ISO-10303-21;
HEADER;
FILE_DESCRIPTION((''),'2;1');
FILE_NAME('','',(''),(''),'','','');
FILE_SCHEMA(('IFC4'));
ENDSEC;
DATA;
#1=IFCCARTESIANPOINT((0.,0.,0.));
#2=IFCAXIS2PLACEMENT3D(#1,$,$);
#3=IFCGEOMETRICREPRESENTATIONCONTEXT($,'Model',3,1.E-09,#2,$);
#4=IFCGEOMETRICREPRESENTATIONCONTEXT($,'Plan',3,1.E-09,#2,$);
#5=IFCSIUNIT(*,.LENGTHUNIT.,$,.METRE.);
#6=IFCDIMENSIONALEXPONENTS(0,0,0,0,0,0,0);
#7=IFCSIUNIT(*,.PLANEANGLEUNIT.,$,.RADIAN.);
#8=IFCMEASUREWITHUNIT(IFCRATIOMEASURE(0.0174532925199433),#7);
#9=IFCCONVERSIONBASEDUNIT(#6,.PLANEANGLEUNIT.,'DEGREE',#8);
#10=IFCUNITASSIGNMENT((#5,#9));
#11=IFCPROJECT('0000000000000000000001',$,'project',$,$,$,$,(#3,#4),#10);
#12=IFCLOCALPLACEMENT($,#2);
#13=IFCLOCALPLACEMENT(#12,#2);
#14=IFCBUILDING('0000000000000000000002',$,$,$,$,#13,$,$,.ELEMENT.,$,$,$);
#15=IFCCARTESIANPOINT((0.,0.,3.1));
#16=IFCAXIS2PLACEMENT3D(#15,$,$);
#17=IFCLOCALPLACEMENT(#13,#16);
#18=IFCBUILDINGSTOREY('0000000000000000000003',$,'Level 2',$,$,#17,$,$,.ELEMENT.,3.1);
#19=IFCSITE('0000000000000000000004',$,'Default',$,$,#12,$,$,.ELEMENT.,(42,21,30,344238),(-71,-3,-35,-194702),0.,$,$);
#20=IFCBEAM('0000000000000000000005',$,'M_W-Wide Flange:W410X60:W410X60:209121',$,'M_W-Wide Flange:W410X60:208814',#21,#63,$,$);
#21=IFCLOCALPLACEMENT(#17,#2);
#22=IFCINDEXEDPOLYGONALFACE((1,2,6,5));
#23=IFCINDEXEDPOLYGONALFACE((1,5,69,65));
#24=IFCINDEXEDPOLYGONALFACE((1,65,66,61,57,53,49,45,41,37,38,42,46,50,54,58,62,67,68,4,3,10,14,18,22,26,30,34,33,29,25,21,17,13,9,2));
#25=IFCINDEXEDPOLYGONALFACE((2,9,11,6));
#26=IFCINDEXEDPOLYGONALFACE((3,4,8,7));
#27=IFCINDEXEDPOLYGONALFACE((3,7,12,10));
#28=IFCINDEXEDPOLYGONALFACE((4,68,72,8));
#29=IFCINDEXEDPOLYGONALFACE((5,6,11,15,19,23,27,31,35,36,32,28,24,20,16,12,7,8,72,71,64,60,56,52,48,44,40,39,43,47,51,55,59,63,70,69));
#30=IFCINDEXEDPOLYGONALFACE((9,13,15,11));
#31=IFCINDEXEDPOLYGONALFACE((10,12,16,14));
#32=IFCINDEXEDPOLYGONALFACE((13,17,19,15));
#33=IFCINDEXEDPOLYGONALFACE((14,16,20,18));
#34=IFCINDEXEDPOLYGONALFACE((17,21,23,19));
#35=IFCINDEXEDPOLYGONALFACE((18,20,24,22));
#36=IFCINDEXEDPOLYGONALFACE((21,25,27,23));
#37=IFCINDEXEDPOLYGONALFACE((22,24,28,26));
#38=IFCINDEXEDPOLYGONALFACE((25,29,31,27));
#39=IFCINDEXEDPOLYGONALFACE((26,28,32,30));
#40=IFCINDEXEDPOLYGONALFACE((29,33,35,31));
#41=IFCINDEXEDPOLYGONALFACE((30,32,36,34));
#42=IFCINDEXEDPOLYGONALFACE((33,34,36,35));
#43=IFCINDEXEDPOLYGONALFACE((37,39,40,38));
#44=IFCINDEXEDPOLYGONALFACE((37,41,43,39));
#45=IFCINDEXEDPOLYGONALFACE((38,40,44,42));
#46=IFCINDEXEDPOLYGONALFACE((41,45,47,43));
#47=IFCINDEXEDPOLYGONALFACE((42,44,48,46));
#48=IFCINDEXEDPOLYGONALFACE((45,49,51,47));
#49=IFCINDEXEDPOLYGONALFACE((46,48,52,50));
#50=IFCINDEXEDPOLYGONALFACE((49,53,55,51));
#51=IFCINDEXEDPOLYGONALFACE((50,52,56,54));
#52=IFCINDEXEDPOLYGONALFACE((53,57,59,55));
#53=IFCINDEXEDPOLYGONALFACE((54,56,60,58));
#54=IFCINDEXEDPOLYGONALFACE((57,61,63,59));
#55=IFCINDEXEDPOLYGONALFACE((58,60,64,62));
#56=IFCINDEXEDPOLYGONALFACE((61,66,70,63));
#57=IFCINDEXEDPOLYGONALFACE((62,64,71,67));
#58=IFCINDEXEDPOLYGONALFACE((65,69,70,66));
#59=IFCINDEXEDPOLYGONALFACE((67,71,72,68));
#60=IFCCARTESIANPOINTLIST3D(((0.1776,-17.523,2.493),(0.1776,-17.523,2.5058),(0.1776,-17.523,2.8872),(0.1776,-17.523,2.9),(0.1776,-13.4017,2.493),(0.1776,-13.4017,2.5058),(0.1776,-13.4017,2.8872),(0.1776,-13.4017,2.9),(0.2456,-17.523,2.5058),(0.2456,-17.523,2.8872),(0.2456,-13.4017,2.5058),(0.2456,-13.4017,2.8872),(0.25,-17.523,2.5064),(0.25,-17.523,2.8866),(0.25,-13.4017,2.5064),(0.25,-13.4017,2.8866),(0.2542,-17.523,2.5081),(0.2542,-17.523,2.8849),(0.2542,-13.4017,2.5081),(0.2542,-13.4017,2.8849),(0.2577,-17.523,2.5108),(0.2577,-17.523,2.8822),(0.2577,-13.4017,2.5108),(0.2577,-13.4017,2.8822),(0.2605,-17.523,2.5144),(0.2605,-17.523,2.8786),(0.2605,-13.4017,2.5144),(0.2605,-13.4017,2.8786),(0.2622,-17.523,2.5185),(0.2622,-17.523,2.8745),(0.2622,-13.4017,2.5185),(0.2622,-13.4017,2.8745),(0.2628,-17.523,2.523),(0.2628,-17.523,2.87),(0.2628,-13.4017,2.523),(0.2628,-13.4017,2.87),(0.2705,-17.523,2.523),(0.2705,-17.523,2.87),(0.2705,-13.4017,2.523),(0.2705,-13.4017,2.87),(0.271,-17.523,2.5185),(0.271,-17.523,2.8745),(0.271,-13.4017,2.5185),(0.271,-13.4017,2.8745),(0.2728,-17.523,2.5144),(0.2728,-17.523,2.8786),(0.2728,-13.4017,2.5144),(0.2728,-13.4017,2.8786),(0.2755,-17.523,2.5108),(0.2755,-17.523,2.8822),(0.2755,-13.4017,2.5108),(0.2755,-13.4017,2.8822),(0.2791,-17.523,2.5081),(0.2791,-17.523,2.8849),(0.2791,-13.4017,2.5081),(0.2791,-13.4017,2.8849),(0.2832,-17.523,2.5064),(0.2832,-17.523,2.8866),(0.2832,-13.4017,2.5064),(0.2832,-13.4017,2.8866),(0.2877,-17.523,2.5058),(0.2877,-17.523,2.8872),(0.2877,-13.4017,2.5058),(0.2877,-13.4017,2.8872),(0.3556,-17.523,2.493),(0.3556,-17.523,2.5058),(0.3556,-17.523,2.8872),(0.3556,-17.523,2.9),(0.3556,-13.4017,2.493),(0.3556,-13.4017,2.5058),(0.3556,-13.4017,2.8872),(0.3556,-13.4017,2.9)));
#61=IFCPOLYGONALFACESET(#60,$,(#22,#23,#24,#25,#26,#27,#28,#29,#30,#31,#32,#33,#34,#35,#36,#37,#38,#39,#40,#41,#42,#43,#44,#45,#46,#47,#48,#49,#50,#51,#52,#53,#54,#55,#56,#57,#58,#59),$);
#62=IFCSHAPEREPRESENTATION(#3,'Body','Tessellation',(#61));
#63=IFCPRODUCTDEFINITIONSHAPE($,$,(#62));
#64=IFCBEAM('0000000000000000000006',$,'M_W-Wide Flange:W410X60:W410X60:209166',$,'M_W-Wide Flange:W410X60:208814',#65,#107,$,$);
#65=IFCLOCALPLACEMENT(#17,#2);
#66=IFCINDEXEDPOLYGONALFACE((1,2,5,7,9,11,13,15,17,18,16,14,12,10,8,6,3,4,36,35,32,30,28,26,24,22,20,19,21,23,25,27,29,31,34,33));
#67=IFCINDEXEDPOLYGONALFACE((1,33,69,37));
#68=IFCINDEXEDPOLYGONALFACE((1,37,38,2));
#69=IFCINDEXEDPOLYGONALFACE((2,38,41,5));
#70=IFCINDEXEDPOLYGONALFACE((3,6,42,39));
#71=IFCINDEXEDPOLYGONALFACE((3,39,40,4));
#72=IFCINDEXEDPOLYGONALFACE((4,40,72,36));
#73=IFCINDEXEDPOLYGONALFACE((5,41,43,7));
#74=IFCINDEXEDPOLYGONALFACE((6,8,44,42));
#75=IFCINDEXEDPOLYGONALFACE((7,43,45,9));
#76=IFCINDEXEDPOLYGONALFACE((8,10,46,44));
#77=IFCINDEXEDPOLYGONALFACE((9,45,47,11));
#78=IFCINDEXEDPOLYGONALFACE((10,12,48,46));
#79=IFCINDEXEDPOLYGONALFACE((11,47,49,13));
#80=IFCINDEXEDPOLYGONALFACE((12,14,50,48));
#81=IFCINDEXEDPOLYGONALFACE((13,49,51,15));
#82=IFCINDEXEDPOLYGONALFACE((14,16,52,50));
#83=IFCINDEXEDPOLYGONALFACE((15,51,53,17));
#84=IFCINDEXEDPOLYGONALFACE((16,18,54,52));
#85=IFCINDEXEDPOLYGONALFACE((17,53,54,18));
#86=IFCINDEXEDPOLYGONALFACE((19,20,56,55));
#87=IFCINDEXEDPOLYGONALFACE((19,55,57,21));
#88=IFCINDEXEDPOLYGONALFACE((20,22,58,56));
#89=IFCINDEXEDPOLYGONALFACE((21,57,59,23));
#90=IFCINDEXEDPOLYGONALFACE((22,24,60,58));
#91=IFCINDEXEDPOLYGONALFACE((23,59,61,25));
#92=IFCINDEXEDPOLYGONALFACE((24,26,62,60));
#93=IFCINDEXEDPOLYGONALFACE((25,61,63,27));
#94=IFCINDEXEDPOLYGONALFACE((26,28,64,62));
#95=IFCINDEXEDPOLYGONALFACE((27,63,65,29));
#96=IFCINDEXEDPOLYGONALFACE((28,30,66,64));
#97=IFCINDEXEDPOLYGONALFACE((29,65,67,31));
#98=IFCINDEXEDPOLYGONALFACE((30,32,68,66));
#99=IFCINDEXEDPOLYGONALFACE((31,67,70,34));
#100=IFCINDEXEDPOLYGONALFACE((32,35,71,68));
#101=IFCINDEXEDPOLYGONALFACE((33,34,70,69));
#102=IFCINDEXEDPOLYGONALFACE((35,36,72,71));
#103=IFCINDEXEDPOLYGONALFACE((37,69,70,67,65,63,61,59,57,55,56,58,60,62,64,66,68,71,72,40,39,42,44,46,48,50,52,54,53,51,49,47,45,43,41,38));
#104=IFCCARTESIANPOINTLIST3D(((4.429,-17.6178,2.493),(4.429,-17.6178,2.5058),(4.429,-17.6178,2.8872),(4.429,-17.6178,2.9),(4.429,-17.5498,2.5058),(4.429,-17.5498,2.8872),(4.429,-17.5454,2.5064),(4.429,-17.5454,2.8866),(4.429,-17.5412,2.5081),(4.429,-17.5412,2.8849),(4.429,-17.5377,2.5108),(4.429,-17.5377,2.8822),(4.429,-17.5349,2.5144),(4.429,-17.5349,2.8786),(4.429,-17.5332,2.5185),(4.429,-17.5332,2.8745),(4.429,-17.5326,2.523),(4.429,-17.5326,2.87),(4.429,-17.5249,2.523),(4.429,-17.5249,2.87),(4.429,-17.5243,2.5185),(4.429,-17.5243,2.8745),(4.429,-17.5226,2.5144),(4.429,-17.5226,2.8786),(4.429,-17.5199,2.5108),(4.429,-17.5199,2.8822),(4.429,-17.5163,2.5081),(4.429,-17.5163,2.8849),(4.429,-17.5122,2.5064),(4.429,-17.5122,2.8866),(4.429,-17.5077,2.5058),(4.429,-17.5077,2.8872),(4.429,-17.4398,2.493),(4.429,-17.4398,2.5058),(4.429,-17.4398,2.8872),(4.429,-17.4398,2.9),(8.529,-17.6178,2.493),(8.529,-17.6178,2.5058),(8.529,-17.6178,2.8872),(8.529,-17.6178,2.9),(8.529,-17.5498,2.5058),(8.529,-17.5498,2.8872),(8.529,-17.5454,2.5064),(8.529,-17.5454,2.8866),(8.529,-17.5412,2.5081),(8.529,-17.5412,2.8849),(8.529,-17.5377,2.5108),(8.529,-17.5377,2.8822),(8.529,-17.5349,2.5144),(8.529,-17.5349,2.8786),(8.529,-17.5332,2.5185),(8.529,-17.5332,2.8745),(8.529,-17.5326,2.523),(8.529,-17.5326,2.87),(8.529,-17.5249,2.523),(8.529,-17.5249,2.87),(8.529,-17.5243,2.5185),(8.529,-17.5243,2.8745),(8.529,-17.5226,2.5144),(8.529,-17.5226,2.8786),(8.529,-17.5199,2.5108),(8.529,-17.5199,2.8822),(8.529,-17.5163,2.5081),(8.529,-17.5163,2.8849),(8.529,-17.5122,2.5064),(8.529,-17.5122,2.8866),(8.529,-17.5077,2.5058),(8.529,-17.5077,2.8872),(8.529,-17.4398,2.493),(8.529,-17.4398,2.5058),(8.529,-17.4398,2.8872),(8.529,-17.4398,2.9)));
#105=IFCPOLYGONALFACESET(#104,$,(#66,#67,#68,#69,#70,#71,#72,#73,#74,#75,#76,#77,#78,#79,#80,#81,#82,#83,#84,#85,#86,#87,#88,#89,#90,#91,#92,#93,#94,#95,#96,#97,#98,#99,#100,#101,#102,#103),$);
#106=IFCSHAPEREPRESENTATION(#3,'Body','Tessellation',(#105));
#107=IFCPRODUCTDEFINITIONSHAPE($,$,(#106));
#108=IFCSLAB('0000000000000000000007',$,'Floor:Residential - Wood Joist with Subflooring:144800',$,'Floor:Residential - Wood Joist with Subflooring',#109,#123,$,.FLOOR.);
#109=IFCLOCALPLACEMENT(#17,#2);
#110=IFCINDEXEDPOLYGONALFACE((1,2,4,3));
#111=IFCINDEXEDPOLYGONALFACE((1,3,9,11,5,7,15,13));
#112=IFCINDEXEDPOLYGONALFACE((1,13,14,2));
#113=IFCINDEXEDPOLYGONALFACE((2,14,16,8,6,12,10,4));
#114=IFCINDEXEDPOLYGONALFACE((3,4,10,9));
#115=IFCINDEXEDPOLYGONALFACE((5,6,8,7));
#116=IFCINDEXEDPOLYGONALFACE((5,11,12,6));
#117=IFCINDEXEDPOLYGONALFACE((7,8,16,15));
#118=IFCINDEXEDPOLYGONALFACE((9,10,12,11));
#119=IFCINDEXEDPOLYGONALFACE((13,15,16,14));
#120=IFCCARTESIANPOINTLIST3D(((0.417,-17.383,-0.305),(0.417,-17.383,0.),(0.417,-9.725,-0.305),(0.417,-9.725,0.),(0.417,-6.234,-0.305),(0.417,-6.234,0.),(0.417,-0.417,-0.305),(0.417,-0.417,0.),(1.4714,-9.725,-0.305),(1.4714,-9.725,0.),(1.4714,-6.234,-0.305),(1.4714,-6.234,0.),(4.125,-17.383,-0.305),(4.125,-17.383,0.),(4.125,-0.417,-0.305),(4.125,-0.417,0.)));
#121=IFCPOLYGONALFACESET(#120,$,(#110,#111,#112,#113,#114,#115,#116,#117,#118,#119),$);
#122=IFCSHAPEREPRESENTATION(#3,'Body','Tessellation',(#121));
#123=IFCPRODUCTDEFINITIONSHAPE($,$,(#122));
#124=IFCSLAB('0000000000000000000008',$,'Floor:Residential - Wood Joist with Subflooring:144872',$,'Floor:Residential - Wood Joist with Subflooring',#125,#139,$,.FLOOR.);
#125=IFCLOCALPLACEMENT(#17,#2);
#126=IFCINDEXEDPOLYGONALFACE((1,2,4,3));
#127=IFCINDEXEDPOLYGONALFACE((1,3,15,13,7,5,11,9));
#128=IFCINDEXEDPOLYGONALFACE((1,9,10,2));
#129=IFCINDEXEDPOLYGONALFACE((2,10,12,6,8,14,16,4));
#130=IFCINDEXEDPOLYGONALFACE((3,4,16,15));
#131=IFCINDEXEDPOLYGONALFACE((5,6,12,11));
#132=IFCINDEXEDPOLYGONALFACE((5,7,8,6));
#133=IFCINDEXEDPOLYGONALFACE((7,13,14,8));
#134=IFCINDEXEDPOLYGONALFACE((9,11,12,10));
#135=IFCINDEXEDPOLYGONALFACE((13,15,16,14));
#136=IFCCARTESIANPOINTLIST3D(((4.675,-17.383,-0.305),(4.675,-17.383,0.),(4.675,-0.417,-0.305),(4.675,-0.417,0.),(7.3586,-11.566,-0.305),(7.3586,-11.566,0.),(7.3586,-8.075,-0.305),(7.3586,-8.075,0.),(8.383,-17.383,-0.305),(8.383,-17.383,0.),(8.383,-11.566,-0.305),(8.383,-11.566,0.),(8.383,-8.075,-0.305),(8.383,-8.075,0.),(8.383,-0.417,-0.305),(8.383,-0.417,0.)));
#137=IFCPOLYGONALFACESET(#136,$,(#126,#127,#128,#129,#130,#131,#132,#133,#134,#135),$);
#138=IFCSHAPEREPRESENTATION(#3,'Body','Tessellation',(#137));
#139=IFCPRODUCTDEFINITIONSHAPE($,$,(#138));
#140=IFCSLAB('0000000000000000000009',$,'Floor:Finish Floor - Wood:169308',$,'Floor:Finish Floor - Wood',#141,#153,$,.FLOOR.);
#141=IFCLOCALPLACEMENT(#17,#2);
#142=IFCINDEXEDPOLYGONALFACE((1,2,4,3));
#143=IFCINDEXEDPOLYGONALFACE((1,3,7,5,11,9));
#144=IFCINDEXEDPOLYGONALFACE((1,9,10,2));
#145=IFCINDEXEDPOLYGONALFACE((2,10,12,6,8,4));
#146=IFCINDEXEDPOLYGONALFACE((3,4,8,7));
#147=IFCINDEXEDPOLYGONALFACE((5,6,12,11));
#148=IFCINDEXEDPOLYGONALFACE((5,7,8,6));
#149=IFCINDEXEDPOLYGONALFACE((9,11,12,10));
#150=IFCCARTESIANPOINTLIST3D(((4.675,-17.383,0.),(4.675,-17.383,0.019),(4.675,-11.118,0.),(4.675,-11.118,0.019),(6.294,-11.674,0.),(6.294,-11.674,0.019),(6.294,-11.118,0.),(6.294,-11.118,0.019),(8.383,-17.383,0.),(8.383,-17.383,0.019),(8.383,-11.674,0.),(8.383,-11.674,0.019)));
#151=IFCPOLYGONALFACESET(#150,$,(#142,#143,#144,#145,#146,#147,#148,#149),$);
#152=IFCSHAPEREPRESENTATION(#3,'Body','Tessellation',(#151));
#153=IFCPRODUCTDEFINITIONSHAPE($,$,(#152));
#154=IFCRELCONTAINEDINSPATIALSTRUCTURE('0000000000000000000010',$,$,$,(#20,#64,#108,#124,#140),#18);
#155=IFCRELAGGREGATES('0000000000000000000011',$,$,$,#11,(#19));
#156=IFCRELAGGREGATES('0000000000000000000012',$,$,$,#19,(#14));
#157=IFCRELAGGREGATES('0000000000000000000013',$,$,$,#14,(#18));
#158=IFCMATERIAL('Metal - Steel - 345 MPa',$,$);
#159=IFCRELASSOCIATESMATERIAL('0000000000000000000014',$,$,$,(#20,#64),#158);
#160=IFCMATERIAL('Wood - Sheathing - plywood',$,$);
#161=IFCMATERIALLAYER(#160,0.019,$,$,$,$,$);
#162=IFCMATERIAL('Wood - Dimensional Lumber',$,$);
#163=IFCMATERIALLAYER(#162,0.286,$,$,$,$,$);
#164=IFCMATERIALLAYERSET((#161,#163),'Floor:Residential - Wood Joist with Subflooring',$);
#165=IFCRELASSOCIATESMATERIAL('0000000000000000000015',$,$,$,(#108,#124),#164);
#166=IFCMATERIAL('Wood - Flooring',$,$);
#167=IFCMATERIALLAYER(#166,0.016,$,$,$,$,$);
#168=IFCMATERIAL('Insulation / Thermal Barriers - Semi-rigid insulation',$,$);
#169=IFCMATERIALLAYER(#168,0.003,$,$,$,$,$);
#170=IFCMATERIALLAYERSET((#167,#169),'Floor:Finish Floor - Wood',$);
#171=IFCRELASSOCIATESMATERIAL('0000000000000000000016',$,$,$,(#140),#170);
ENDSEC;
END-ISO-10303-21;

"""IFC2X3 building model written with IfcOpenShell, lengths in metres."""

from ifc_helpers import new_model, entity, si_unit, converted_unit, frame, frame_2d, origin, place, context, project, spatial, polyline, circle_curve, parameter, trimmed, segment, composite_curve, outline, extrude, material, layer, layer_set, layer_usage, element, save


model = new_model("IFC2X3")

# Units and contexts
model_context = context("Model", 3, precision=1e-09, world=origin())
plan_context = context("Plan", 3, precision=1e-09, world=origin())
ifc_project = project(units=[si_unit("LENGTHUNIT", "METRE"), converted_unit("PLANEANGLEUNIT", "DEGREE", entity("IfcRatioMeasure", 0.0174532925199433), si_unit("PLANEANGLEUNIT", "RADIAN"), dimensions=[0, 0, 0, 0, 0, 0, 0])], contexts=[model_context, plan_context])

# Site, building, storey
site_placement = place(None, origin())
site = spatial("IfcSite", under=ifc_project, at=site_placement, Name="Default", CompositionType="ELEMENT", RefLatitude=(42, 21, 30, 344238), RefLongitude=(-71, -3, -35, -194702), RefElevation=0.0)
building_placement = place(site_placement, origin())
building = spatial("IfcBuilding", under=site, at=building_placement, CompositionType="ELEMENT")
storey_placement = place(building_placement, frame((0.0, 0.0, 3.1)))
storey = spatial("IfcBuildingStorey", under=building, at=storey_placement, Name="Level 2", CompositionType="ELEMENT", Elevation=3.1)

# Beams
ifc_material_1 = material(Name="Metal - Steel - 345 MPa")
beam_1_placement = place(storey_placement, frame((0.2666, -13.4017, 2.9), z_axis=(0.0, 0.0, 1.0), x_axis=(-1.0, 0.0, 0.0)))
element("IfcBeam", 1, at=beam_1_placement, inside=storey, material=ifc_material_1, Name="M_W-Wide Flange:W410X60:W410X60:209121", ObjectType="M_W-Wide Flange:W410X60:208814", context=model_context, shape_type="SweptSolid", body=[
    extrude(outline(composite_curve([segment(polyline([(0.1907, -0.089), (0.2035, -0.089)]), True, "CONTINUOUS"), segment(polyline([(0.2035, -0.089), (0.2035, 0.089)]), True, "CONTINUOUS"), segment(polyline([(0.2035, 0.089), (0.1907, 0.089)]), True, "CONTINUOUS"), segment(polyline([(0.1907, 0.089), (0.1907, 0.021)]), True, "CONTINUOUS"), segment(trimmed(circle_curve(frame_2d((0.1735, 0.021), x_axis=(1.0, 0.0)), 0.0172), [parameter(270.0)], [parameter(360.0)], True, "PARAMETER"), False, "CONTINUOUS"), segment(polyline([(0.1735, 0.0038), (-0.1735, 0.0038)]), True, "CONTINUOUS"), segment(trimmed(circle_curve(frame_2d((-0.1735, 0.021), x_axis=(0.0, -1.0)), 0.0172), [parameter(270.0)], [parameter(360.0)], True, "PARAMETER"), False, "CONTINUOUS"), segment(polyline([(-0.1907, 0.021), (-0.1907, 0.089)]), True, "CONTINUOUS"), segment(polyline([(-0.1907, 0.089), (-0.2035, 0.089)]), True, "CONTINUOUS"), segment(polyline([(-0.2035, 0.089), (-0.2035, -0.089)]), True, "CONTINUOUS"), segment(polyline([(-0.2035, -0.089), (-0.1907, -0.089)]), True, "CONTINUOUS"), segment(polyline([(-0.1907, -0.089), (-0.1907, -0.0211)]), True, "CONTINUOUS"), segment(trimmed(circle_curve(frame_2d((-0.1735, -0.0211), x_axis=(-1.0, 0.0)), 0.0172), [parameter(270.0)], [parameter(0.0)], True, "PARAMETER"), False, "CONTINUOUS"), segment(polyline([(-0.1735, -0.0039), (0.1735, -0.0039)]), True, "CONTINUOUS"), segment(trimmed(circle_curve(frame_2d((0.1735, -0.0211), x_axis=(0.0, 1.0)), 0.0172), [parameter(270.0)], [parameter(0.0)], True, "PARAMETER"), False, "CONTINUOUS"), segment(polyline([(0.1907, -0.0211), (0.1907, -0.089)]), True, "CONTINUOUS")], self_intersect=False)), frame((0.0, 4.1213, -0.2035), z_axis=(0.0, -1.0, 0.0), x_axis=(0.0, 0.0, -1.0)), (0.0, 0.0, 1.0), 4.1213),
])
beam_2_placement = place(storey_placement, frame((4.429, -17.5288, 2.9), z_axis=(0.0, 0.0, 1.0), x_axis=(0.0, -1.0, 0.0)))
element("IfcBeam", 2, at=beam_2_placement, inside=storey, material=ifc_material_1, Name="M_W-Wide Flange:W410X60:W410X60:209166", ObjectType="M_W-Wide Flange:W410X60:208814", context=model_context, shape_type="SweptSolid", body=[
    extrude(outline(composite_curve([segment(polyline([(-0.089, -0.1907), (-0.089, -0.2035)]), True, "CONTINUOUS"), segment(polyline([(-0.089, -0.2035), (0.089, -0.2035)]), True, "CONTINUOUS"), segment(polyline([(0.089, -0.2035), (0.089, -0.1907)]), True, "CONTINUOUS"), segment(polyline([(0.089, -0.1907), (0.021, -0.1907)]), True, "CONTINUOUS"), segment(trimmed(circle_curve(frame_2d((0.021, -0.1735), x_axis=(0.0, -1.0)), 0.0172), [parameter(270.0)], [parameter(360.0)], True, "PARAMETER"), False, "CONTINUOUS"), segment(polyline([(0.0038, -0.1735), (0.0038, 0.1735)]), True, "CONTINUOUS"), segment(trimmed(circle_curve(frame_2d((0.021, 0.1735), x_axis=(-1.0, 0.0)), 0.0172), [parameter(270.0)], [parameter(360.0)], True, "PARAMETER"), False, "CONTINUOUS"), segment(polyline([(0.021, 0.1907), (0.089, 0.1907)]), True, "CONTINUOUS"), segment(polyline([(0.089, 0.1907), (0.089, 0.2035)]), True, "CONTINUOUS"), segment(polyline([(0.089, 0.2035), (-0.089, 0.2035)]), True, "CONTINUOUS"), segment(polyline([(-0.089, 0.2035), (-0.089, 0.1907)]), True, "CONTINUOUS"), segment(polyline([(-0.089, 0.1907), (-0.0211, 0.1907)]), True, "CONTINUOUS"), segment(trimmed(circle_curve(frame_2d((-0.0211, 0.1735), x_axis=(0.0, 1.0)), 0.0172), [parameter(270.0)], [parameter(0.0)], True, "PARAMETER"), False, "CONTINUOUS"), segment(polyline([(-0.0039, 0.1735), (-0.0039, -0.1735)]), True, "CONTINUOUS"), segment(trimmed(circle_curve(frame_2d((-0.0211, -0.1735), x_axis=(1.0, 0.0)), 0.0172), [parameter(270.0)], [parameter(0.0)], True, "PARAMETER"), False, "CONTINUOUS"), segment(polyline([(-0.0211, -0.1907), (-0.089, -0.1907)]), True, "CONTINUOUS")], self_intersect=False)), frame((0.0, 0.0, -0.2035), z_axis=(0.0, -1.0, 0.0), x_axis=(1.0, 0.0, 0.0)), (0.0, 0.0, -1.0), 4.1),
])

# Slabs
ifc_material_2 = material(Name="Wood - Sheathing - plywood")
ifc_layer_1 = layer(ifc_material_2, 0.019)
ifc_material_3 = material(Name="Wood - Dimensional Lumber")
ifc_layer_2 = layer(ifc_material_3, 0.286)
ifc_layer_set_1 = layer_set([ifc_layer_1, ifc_layer_2], Name="Floor:Residential - Wood Joist with Subflooring")
ifc_layer_usage_1 = layer_usage(ifc_layer_set_1, "AXIS3", "POSITIVE", 0.0)
slab_1_placement = place(storey_placement, frame((0.417, -17.383, -0.305)))
element("IfcSlab", 3, at=slab_1_placement, inside=storey, material=ifc_layer_usage_1, Name="Floor:Residential - Wood Joist with Subflooring:144800", ObjectType="Floor:Residential - Wood Joist with Subflooring", PredefinedType="FLOOR", context=model_context, shape_type="SweptSolid", body=[
    extrude(outline(polyline([(-1.854, 8.483), (-1.854, -8.483), (1.854, -8.483), (1.854, -0.825), (0.7996, -0.825), (0.7996, 2.666), (1.854, 2.666), (1.854, 8.483), (-1.854, 8.483)])), frame((1.854, 8.483, 0.305), z_axis=(0.0, 0.0, -1.0), x_axis=(-1.0, 0.0, 0.0)), (0.0, 0.0, 1.0), 0.305),
])
slab_2_placement = place(storey_placement, frame((4.675, -17.383, -0.305)))
element("IfcSlab", 4, at=slab_2_placement, inside=storey, material=ifc_layer_usage_1, Name="Floor:Residential - Wood Joist with Subflooring:144872", ObjectType="Floor:Residential - Wood Joist with Subflooring", PredefinedType="FLOOR", context=model_context, shape_type="SweptSolid", body=[
    extrude(outline(polyline([(-1.854, 8.483), (-1.854, 0.825), (-0.8296, 0.825), (-0.8296, -2.666), (-1.854, -2.666), (-1.854, -8.483), (1.854, -8.483), (1.854, 8.483), (-1.854, 8.483)])), frame((1.854, 8.483, 0.305), z_axis=(0.0, 0.0, -1.0), x_axis=(-1.0, 0.0, 0.0)), (0.0, 0.0, 1.0), 0.305),
])
ifc_material_4 = material(Name="Wood - Flooring")
ifc_layer_3 = layer(ifc_material_4, 0.016)
ifc_material_5 = material(Name="Insulation / Thermal Barriers - Semi-rigid insulation")
ifc_layer_4 = layer(ifc_material_5, 0.003)
ifc_layer_set_2 = layer_set([ifc_layer_3, ifc_layer_4], Name="Floor:Finish Floor - Wood")
ifc_layer_usage_2 = layer_usage(ifc_layer_set_2, "AXIS3", "POSITIVE", 0.0)
slab_3_placement = place(storey_placement, frame((4.675, -17.383, 0.0)))
element("IfcSlab", 5, at=slab_3_placement, inside=storey, material=ifc_layer_usage_2, Name="Floor:Finish Floor - Wood:169308", ObjectType="Floor:Finish Floor - Wood", PredefinedType="FLOOR", context=model_context, shape_type="SweptSolid", body=[
    extrude(outline(polyline([(-1.854, 2.5765), (-1.854, -3.1325), (1.854, -3.1325), (1.854, 3.1325), (0.235, 3.1325), (0.235, 2.5765), (-1.854, 2.5765)])), frame((1.854, 3.1325, 0.019), z_axis=(0.0, 0.0, -1.0), x_axis=(-1.0, 0.0, 0.0)), (0.0, 0.0, 1.0), 0.019),
])

save(model, "model.ifc")
